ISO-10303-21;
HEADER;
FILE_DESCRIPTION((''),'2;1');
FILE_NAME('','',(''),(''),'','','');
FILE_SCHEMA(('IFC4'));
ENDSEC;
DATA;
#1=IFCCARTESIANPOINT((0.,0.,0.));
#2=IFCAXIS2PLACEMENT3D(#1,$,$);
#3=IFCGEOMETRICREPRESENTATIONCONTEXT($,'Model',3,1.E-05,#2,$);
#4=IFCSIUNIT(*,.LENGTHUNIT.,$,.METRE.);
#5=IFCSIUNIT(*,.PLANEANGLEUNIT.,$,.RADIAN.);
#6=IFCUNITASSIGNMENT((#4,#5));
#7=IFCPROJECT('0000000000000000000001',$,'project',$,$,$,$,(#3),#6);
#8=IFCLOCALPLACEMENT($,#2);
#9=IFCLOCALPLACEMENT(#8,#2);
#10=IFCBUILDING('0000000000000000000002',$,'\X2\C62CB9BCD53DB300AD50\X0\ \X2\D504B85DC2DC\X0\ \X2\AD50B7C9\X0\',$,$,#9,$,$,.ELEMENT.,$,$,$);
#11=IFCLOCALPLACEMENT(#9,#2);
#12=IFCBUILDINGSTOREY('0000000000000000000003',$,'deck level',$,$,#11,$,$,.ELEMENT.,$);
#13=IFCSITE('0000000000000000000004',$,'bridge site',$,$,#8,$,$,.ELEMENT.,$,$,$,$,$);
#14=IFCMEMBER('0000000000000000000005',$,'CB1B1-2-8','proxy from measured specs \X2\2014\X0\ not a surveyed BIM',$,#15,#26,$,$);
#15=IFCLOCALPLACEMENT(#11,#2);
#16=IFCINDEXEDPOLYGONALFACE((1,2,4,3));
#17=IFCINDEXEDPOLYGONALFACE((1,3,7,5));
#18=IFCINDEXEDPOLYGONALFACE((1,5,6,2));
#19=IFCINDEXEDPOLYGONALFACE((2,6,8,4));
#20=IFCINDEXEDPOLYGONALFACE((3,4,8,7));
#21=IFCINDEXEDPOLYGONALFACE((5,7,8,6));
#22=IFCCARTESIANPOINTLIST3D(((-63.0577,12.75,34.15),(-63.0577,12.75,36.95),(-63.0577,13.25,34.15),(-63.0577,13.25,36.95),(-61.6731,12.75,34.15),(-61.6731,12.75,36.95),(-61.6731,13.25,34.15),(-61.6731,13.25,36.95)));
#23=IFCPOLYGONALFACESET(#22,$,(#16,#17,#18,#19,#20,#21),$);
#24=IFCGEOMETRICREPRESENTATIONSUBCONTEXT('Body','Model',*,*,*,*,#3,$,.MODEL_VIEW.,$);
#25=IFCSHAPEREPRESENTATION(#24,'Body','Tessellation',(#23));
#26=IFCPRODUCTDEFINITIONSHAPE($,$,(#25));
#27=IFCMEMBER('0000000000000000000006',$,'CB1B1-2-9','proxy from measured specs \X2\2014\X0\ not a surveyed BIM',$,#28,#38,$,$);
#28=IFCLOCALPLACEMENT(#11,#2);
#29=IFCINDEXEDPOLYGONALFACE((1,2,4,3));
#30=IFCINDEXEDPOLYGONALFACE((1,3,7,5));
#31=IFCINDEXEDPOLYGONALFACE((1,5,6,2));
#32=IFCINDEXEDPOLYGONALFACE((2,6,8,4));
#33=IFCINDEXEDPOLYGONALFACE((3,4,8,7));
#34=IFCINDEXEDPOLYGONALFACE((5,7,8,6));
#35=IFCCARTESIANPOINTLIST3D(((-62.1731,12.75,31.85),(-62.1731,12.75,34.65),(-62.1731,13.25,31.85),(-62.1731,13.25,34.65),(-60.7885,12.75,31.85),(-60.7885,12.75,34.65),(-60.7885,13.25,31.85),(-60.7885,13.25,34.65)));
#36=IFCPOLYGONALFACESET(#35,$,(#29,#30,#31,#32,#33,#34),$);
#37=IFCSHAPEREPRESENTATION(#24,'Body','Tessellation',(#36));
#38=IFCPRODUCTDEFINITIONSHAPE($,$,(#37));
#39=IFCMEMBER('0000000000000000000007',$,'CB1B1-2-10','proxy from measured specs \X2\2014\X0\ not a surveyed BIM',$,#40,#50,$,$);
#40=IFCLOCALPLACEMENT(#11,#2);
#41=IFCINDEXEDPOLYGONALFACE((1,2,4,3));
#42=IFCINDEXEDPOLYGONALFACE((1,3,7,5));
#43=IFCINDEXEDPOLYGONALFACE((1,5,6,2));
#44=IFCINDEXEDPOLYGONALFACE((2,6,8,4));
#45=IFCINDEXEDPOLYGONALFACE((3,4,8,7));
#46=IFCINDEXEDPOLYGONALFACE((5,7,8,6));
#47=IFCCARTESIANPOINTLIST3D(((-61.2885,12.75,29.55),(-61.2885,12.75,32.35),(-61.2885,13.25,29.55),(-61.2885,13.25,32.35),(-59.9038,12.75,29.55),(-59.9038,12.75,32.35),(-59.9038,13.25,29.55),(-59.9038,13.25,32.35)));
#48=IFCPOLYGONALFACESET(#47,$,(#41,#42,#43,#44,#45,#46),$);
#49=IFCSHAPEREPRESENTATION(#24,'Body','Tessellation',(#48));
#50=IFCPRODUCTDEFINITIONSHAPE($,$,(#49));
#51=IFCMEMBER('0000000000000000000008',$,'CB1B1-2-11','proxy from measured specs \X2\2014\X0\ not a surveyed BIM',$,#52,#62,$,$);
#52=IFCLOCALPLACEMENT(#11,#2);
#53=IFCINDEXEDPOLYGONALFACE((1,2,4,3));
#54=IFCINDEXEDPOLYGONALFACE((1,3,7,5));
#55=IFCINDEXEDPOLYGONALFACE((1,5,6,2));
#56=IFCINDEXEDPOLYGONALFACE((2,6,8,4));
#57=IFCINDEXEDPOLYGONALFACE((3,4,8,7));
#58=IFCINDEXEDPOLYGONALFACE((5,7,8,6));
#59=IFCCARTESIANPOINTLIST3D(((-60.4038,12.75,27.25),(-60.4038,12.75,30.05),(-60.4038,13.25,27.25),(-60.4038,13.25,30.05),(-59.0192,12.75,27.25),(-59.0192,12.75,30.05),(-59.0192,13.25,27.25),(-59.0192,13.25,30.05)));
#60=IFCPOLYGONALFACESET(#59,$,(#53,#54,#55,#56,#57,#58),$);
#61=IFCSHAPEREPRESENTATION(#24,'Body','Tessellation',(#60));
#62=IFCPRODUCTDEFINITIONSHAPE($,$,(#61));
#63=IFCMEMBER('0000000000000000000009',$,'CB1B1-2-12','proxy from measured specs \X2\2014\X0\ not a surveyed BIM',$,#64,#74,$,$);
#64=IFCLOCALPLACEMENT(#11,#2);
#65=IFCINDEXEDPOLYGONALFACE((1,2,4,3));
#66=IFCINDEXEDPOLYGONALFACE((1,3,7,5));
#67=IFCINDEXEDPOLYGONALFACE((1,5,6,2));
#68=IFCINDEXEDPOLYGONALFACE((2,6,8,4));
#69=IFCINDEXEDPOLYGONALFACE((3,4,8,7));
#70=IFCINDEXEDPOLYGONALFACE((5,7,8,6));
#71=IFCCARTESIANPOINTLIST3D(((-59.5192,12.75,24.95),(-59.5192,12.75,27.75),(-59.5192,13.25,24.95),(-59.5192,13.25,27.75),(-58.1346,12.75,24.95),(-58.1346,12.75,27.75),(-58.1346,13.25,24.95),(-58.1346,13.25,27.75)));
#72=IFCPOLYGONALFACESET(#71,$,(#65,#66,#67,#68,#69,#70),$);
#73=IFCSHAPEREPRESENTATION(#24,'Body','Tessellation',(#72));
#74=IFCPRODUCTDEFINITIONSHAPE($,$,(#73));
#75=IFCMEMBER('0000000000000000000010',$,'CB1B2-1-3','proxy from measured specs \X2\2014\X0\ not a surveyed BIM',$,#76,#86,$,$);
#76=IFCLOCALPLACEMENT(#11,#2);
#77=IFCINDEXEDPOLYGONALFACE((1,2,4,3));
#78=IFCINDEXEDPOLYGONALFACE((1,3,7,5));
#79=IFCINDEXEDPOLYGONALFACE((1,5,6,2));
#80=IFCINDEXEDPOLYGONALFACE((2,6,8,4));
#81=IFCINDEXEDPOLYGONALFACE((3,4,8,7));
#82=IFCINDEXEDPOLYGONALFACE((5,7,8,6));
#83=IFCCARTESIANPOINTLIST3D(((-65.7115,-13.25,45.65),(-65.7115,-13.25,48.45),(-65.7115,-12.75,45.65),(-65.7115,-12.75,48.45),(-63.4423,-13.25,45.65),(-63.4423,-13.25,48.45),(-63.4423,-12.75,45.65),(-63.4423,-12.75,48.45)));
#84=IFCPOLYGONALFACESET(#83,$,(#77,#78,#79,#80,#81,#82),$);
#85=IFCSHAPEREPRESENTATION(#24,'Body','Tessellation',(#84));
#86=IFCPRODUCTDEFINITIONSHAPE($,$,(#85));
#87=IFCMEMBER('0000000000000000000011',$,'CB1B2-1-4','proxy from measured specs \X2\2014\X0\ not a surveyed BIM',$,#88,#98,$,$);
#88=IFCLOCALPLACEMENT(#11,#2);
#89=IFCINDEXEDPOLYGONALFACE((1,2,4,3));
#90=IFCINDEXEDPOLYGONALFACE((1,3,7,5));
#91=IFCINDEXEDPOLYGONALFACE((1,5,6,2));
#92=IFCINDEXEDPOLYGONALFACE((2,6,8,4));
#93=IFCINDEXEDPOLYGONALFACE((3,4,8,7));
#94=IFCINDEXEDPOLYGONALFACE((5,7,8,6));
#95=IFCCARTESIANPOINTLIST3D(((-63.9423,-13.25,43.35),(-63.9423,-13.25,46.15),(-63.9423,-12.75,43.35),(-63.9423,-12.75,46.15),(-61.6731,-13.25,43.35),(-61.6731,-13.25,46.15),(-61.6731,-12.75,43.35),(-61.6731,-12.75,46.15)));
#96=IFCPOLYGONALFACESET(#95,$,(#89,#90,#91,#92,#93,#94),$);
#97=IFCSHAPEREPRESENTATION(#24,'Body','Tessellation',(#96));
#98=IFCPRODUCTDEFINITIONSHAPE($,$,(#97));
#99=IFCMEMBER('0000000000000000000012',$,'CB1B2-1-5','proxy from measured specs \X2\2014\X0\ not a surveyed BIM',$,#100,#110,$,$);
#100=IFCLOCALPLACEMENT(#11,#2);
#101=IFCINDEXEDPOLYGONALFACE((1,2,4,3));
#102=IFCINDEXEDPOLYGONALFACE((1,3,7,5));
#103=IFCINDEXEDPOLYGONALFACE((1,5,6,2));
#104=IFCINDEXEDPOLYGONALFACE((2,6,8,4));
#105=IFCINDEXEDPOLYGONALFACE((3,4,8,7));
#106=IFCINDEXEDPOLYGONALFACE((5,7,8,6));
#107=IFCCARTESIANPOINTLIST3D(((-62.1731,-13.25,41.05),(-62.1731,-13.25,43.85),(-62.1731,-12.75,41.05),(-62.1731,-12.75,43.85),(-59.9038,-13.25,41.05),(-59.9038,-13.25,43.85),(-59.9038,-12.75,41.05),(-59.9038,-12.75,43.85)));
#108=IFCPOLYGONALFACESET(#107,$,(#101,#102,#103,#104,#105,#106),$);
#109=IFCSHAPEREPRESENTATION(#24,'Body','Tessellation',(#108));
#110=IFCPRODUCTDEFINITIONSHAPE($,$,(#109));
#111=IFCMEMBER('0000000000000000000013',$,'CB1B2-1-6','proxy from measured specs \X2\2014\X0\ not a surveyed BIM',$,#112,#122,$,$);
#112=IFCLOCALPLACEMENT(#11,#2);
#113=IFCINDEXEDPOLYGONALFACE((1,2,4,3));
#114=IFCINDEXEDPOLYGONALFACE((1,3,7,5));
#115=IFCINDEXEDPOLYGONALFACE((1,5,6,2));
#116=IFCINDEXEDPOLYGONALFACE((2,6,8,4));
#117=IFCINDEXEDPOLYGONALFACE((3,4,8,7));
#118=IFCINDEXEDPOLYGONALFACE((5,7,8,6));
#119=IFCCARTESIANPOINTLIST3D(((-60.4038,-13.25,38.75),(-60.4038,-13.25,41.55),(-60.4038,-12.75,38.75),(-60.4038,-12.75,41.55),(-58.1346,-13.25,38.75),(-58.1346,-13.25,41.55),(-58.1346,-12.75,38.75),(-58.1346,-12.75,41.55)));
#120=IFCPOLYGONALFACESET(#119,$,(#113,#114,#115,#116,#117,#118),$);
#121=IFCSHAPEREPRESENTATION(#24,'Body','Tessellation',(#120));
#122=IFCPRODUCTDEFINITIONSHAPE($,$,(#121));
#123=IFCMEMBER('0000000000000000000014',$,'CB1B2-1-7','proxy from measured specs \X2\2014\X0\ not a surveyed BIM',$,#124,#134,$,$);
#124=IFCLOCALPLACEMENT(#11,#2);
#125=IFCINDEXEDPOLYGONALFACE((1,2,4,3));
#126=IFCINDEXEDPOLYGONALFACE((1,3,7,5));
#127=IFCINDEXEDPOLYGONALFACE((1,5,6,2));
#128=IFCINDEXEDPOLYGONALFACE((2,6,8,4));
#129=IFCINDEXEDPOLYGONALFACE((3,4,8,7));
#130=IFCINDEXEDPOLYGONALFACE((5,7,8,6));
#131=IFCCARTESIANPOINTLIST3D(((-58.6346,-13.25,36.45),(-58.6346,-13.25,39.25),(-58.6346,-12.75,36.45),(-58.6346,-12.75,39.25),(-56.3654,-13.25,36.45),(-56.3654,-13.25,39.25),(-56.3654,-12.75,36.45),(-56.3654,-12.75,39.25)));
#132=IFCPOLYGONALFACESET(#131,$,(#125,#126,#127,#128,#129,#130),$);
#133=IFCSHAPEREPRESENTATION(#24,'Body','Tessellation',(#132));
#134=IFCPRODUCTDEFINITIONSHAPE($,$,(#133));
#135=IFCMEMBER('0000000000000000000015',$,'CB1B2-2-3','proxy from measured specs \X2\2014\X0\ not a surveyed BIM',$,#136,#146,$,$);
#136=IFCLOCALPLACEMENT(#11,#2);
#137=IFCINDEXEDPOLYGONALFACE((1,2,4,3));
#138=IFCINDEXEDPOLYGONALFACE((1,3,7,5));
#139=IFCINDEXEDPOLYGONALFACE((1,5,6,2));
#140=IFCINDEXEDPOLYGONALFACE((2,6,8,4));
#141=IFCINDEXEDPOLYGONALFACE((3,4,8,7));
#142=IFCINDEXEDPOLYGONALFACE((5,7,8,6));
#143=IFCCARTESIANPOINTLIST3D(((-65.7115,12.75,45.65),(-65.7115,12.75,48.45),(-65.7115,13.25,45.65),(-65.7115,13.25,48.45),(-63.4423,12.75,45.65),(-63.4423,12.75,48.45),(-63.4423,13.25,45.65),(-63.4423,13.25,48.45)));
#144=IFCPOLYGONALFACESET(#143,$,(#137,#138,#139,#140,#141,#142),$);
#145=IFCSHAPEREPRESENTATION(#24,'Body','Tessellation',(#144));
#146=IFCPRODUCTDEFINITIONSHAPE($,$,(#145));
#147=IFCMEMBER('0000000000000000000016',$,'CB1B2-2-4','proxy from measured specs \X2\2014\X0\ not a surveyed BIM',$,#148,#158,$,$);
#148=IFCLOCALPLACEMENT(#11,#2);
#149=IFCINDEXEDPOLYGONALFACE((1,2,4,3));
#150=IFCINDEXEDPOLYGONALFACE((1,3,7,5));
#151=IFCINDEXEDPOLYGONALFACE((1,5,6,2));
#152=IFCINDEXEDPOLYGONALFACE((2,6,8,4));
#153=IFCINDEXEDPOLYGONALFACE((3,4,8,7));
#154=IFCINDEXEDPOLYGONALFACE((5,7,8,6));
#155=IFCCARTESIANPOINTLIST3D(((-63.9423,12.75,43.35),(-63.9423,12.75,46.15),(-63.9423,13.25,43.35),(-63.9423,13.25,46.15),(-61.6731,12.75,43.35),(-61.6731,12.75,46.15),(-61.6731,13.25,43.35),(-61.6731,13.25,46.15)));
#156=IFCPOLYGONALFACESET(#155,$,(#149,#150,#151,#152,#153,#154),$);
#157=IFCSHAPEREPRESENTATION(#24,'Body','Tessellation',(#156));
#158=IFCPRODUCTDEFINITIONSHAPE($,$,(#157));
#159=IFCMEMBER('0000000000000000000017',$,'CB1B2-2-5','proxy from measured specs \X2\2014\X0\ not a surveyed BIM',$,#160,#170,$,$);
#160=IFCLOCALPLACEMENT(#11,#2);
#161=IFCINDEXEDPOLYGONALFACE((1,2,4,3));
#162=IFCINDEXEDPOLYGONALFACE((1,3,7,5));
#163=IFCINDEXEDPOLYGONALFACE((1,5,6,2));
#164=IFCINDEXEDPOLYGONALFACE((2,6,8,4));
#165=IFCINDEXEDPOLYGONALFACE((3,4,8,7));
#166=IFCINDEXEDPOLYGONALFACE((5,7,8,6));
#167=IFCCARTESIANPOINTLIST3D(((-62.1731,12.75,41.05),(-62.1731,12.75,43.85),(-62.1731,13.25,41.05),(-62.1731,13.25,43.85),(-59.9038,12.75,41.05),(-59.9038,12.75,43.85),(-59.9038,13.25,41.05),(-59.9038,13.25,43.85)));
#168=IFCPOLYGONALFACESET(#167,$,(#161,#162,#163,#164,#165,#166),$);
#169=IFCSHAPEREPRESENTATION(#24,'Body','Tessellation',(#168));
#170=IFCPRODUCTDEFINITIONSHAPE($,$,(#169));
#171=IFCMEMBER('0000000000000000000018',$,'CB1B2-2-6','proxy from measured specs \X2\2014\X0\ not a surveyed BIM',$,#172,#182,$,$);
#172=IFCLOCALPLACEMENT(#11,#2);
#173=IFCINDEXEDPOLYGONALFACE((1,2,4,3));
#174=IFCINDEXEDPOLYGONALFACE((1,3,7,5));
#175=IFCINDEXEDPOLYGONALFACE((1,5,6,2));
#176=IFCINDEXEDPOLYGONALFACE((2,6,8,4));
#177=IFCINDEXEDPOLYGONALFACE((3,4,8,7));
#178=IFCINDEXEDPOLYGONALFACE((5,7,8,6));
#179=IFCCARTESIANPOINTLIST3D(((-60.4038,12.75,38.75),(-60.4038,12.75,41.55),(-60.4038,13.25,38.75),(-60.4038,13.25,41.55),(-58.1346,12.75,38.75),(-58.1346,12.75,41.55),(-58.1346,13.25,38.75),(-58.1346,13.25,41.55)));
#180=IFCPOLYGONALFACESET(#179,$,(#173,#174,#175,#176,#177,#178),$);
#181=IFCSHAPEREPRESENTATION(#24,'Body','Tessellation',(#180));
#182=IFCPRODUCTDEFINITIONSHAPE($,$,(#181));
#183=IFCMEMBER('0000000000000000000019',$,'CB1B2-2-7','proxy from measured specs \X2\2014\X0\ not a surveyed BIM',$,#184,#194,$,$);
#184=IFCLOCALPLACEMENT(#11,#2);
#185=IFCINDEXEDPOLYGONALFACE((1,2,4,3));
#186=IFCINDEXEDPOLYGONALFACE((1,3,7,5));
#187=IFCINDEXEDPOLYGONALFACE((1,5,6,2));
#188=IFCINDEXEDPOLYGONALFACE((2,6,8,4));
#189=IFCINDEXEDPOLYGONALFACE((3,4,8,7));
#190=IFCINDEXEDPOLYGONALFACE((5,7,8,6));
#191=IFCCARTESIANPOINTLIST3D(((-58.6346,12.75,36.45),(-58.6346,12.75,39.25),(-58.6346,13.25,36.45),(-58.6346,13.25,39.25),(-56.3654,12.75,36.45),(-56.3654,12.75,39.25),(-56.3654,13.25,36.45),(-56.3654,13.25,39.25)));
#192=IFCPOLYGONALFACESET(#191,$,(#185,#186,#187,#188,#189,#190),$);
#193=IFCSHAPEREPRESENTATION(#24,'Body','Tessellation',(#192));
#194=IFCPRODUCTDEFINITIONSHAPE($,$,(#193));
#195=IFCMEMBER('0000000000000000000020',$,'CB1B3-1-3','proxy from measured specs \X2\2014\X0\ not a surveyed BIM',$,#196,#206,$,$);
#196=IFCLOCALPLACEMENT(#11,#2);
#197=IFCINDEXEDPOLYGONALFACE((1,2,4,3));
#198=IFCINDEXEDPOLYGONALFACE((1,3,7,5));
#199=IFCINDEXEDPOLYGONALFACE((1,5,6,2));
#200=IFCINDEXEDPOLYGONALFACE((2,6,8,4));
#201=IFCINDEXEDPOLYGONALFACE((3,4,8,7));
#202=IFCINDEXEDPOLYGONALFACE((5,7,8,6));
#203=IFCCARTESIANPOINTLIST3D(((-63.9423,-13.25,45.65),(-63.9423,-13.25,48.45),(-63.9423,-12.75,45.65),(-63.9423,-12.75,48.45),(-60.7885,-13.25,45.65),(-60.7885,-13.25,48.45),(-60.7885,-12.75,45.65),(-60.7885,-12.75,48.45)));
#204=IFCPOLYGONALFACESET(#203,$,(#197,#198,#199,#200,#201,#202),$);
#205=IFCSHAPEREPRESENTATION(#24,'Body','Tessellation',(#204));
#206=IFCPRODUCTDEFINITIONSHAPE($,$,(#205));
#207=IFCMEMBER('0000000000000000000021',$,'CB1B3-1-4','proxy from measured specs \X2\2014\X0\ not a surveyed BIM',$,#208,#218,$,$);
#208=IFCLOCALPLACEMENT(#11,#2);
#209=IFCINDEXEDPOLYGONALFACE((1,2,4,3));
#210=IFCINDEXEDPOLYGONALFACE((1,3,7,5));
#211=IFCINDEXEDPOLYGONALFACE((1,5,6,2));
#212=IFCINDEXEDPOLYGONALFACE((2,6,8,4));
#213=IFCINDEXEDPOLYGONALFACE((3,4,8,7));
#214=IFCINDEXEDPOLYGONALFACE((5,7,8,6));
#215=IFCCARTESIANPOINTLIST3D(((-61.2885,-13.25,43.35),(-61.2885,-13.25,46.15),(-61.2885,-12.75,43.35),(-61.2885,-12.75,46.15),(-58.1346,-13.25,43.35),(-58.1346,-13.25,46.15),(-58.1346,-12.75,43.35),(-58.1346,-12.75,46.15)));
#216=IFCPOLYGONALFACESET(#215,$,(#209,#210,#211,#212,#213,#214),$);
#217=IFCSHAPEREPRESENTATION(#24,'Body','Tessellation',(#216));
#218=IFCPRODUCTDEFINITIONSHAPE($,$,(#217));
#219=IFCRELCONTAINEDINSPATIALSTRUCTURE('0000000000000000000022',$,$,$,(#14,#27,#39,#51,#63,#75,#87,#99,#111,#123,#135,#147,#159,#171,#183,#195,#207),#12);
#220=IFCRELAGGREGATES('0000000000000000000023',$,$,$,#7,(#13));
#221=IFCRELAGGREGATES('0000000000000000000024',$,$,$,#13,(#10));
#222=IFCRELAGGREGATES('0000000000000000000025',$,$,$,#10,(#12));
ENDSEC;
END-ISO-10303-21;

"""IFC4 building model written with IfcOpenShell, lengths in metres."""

from ifc_helpers import new_model, si_unit, frame, origin, origin_2d, place, context, subcontext, project, spatial, rectangle, extrude, element, save


model = new_model("IFC4")

# Units and contexts
model_context = context("Model", 3, precision=1e-05, world=origin())
body_context = subcontext(model_context, "Body", "Model", "MODEL_VIEW")
ifc_project = project(units=[si_unit("LENGTHUNIT", "METRE"), si_unit("PLANEANGLEUNIT", "RADIAN")], contexts=[model_context])

# Site, building, storey
site_placement = place(None, origin())
site = spatial("IfcSite", under=ifc_project, at=site_placement, Name="bridge site", CompositionType="ELEMENT")
building_placement = place(site_placement, origin())
building = spatial("IfcBuilding", under=site, at=building_placement, Name="올림픽대교 프록시 교량", CompositionType="ELEMENT")
storey_placement = place(building_placement, origin())
storey = spatial("IfcBuildingStorey", under=building, at=storey_placement, Name="deck level", CompositionType="ELEMENT")

# Members
member_1_placement = place(storey_placement, frame((-62.3654, 13.0, 34.15)))
element("IfcMember", 1, at=member_1_placement, inside=storey, Name="CB1B1-2-8", Description="proxy from measured specs — not a surveyed BIM", context=body_context, shape_type="SweptSolid", body=[
    extrude(rectangle(XDim=1.3846, YDim=0.5, at=origin_2d()), origin(), (0.0, 0.0, 1.0), 2.8),
])
member_2_placement = place(storey_placement, frame((-61.4808, 13.0, 31.85)))
element("IfcMember", 2, at=member_2_placement, inside=storey, Name="CB1B1-2-9", Description="proxy from measured specs — not a surveyed BIM", context=body_context, shape_type="SweptSolid", body=[
    extrude(rectangle(XDim=1.3846, YDim=0.5, at=origin_2d()), origin(), (0.0, 0.0, 1.0), 2.8),
])
member_3_placement = place(storey_placement, frame((-60.5962, 13.0, 29.55)))
element("IfcMember", 3, at=member_3_placement, inside=storey, Name="CB1B1-2-10", Description="proxy from measured specs — not a surveyed BIM", context=body_context, shape_type="SweptSolid", body=[
    extrude(rectangle(XDim=1.3846, YDim=0.5, at=origin_2d()), origin(), (0.0, 0.0, 1.0), 2.8),
])
member_4_placement = place(storey_placement, frame((-59.7115, 13.0, 27.25)))
element("IfcMember", 4, at=member_4_placement, inside=storey, Name="CB1B1-2-11", Description="proxy from measured specs — not a surveyed BIM", context=body_context, shape_type="SweptSolid", body=[
    extrude(rectangle(XDim=1.3846, YDim=0.5, at=origin_2d()), origin(), (0.0, 0.0, 1.0), 2.8),
])
member_5_placement = place(storey_placement, frame((-58.8269, 13.0, 24.95)))
element("IfcMember", 5, at=member_5_placement, inside=storey, Name="CB1B1-2-12", Description="proxy from measured specs — not a surveyed BIM", context=body_context, shape_type="SweptSolid", body=[
    extrude(rectangle(XDim=1.3846, YDim=0.5, at=origin_2d()), origin(), (0.0, 0.0, 1.0), 2.8),
])
member_6_placement = place(storey_placement, frame((-64.5769, -13.0, 45.65)))
element("IfcMember", 6, at=member_6_placement, inside=storey, Name="CB1B2-1-3", Description="proxy from measured specs — not a surveyed BIM", context=body_context, shape_type="SweptSolid", body=[
    extrude(rectangle(XDim=2.2692, YDim=0.5, at=origin_2d()), origin(), (0.0, 0.0, 1.0), 2.8),
])
member_7_placement = place(storey_placement, frame((-62.8077, -13.0, 43.35)))
element("IfcMember", 7, at=member_7_placement, inside=storey, Name="CB1B2-1-4", Description="proxy from measured specs — not a surveyed BIM", context=body_context, shape_type="SweptSolid", body=[
    extrude(rectangle(XDim=2.2692, YDim=0.5, at=origin_2d()), origin(), (0.0, 0.0, 1.0), 2.8),
])
member_8_placement = place(storey_placement, frame((-61.0385, -13.0, 41.05)))
element("IfcMember", 8, at=member_8_placement, inside=storey, Name="CB1B2-1-5", Description="proxy from measured specs — not a surveyed BIM", context=body_context, shape_type="SweptSolid", body=[
    extrude(rectangle(XDim=2.2692, YDim=0.5, at=origin_2d()), origin(), (0.0, 0.0, 1.0), 2.8),
])
for number, where, name in (
    (9, (-59.2692, -13.0, 38.75), "CB1B2-1-6"),
    (10, (-57.5, -13.0, 36.45), "CB1B2-1-7"),
):
    element("IfcMember", number, at=place(storey_placement, frame(where)), inside=storey, Name=name, Description="proxy from measured specs — not a surveyed BIM", context=body_context, shape_type="SweptSolid", body=[
        extrude(rectangle(XDim=2.2692, YDim=0.5, at=origin_2d()), origin(), (0.0, 0.0, 1.0), 2.8),
    ])
member_9_placement = place(storey_placement, frame((-64.5769, 13.0, 45.65)))
element("IfcMember", 11, at=member_9_placement, inside=storey, Name="CB1B2-2-3", Description="proxy from measured specs — not a surveyed BIM", context=body_context, shape_type="SweptSolid", body=[
    extrude(rectangle(XDim=2.2692, YDim=0.5, at=origin_2d()), origin(), (0.0, 0.0, 1.0), 2.8),
])
member_10_placement = place(storey_placement, frame((-62.8077, 13.0, 43.35)))
element("IfcMember", 12, at=member_10_placement, inside=storey, Name="CB1B2-2-4", Description="proxy from measured specs — not a surveyed BIM", context=body_context, shape_type="SweptSolid", body=[
    extrude(rectangle(XDim=2.2692, YDim=0.5, at=origin_2d()), origin(), (0.0, 0.0, 1.0), 2.8),
])
member_11_placement = place(storey_placement, frame((-61.0385, 13.0, 41.05)))
element("IfcMember", 13, at=member_11_placement, inside=storey, Name="CB1B2-2-5", Description="proxy from measured specs — not a surveyed BIM", context=body_context, shape_type="SweptSolid", body=[
    extrude(rectangle(XDim=2.2692, YDim=0.5, at=origin_2d()), origin(), (0.0, 0.0, 1.0), 2.8),
])
for number, where, name in (
    (14, (-59.2692, 13.0, 38.75), "CB1B2-2-6"),
    (15, (-57.5, 13.0, 36.45), "CB1B2-2-7"),
):
    element("IfcMember", number, at=place(storey_placement, frame(where)), inside=storey, Name=name, Description="proxy from measured specs — not a surveyed BIM", context=body_context, shape_type="SweptSolid", body=[
        extrude(rectangle(XDim=2.2692, YDim=0.5, at=origin_2d()), origin(), (0.0, 0.0, 1.0), 2.8),
    ])
member_12_placement = place(storey_placement, frame((-62.3654, -13.0, 45.65)))
element("IfcMember", 16, at=member_12_placement, inside=storey, Name="CB1B3-1-3", Description="proxy from measured specs — not a surveyed BIM", context=body_context, shape_type="SweptSolid", body=[
    extrude(rectangle(XDim=3.1538, YDim=0.5, at=origin_2d()), origin(), (0.0, 0.0, 1.0), 2.8),
])
member_13_placement = place(storey_placement, frame((-59.7115, -13.0, 43.35)))
element("IfcMember", 17, at=member_13_placement, inside=storey, Name="CB1B3-1-4", Description="proxy from measured specs — not a surveyed BIM", context=body_context, shape_type="SweptSolid", body=[
    extrude(rectangle(XDim=3.1538, YDim=0.5, at=origin_2d()), origin(), (0.0, 0.0, 1.0), 2.8),
])

save(model, "model.ifc")
